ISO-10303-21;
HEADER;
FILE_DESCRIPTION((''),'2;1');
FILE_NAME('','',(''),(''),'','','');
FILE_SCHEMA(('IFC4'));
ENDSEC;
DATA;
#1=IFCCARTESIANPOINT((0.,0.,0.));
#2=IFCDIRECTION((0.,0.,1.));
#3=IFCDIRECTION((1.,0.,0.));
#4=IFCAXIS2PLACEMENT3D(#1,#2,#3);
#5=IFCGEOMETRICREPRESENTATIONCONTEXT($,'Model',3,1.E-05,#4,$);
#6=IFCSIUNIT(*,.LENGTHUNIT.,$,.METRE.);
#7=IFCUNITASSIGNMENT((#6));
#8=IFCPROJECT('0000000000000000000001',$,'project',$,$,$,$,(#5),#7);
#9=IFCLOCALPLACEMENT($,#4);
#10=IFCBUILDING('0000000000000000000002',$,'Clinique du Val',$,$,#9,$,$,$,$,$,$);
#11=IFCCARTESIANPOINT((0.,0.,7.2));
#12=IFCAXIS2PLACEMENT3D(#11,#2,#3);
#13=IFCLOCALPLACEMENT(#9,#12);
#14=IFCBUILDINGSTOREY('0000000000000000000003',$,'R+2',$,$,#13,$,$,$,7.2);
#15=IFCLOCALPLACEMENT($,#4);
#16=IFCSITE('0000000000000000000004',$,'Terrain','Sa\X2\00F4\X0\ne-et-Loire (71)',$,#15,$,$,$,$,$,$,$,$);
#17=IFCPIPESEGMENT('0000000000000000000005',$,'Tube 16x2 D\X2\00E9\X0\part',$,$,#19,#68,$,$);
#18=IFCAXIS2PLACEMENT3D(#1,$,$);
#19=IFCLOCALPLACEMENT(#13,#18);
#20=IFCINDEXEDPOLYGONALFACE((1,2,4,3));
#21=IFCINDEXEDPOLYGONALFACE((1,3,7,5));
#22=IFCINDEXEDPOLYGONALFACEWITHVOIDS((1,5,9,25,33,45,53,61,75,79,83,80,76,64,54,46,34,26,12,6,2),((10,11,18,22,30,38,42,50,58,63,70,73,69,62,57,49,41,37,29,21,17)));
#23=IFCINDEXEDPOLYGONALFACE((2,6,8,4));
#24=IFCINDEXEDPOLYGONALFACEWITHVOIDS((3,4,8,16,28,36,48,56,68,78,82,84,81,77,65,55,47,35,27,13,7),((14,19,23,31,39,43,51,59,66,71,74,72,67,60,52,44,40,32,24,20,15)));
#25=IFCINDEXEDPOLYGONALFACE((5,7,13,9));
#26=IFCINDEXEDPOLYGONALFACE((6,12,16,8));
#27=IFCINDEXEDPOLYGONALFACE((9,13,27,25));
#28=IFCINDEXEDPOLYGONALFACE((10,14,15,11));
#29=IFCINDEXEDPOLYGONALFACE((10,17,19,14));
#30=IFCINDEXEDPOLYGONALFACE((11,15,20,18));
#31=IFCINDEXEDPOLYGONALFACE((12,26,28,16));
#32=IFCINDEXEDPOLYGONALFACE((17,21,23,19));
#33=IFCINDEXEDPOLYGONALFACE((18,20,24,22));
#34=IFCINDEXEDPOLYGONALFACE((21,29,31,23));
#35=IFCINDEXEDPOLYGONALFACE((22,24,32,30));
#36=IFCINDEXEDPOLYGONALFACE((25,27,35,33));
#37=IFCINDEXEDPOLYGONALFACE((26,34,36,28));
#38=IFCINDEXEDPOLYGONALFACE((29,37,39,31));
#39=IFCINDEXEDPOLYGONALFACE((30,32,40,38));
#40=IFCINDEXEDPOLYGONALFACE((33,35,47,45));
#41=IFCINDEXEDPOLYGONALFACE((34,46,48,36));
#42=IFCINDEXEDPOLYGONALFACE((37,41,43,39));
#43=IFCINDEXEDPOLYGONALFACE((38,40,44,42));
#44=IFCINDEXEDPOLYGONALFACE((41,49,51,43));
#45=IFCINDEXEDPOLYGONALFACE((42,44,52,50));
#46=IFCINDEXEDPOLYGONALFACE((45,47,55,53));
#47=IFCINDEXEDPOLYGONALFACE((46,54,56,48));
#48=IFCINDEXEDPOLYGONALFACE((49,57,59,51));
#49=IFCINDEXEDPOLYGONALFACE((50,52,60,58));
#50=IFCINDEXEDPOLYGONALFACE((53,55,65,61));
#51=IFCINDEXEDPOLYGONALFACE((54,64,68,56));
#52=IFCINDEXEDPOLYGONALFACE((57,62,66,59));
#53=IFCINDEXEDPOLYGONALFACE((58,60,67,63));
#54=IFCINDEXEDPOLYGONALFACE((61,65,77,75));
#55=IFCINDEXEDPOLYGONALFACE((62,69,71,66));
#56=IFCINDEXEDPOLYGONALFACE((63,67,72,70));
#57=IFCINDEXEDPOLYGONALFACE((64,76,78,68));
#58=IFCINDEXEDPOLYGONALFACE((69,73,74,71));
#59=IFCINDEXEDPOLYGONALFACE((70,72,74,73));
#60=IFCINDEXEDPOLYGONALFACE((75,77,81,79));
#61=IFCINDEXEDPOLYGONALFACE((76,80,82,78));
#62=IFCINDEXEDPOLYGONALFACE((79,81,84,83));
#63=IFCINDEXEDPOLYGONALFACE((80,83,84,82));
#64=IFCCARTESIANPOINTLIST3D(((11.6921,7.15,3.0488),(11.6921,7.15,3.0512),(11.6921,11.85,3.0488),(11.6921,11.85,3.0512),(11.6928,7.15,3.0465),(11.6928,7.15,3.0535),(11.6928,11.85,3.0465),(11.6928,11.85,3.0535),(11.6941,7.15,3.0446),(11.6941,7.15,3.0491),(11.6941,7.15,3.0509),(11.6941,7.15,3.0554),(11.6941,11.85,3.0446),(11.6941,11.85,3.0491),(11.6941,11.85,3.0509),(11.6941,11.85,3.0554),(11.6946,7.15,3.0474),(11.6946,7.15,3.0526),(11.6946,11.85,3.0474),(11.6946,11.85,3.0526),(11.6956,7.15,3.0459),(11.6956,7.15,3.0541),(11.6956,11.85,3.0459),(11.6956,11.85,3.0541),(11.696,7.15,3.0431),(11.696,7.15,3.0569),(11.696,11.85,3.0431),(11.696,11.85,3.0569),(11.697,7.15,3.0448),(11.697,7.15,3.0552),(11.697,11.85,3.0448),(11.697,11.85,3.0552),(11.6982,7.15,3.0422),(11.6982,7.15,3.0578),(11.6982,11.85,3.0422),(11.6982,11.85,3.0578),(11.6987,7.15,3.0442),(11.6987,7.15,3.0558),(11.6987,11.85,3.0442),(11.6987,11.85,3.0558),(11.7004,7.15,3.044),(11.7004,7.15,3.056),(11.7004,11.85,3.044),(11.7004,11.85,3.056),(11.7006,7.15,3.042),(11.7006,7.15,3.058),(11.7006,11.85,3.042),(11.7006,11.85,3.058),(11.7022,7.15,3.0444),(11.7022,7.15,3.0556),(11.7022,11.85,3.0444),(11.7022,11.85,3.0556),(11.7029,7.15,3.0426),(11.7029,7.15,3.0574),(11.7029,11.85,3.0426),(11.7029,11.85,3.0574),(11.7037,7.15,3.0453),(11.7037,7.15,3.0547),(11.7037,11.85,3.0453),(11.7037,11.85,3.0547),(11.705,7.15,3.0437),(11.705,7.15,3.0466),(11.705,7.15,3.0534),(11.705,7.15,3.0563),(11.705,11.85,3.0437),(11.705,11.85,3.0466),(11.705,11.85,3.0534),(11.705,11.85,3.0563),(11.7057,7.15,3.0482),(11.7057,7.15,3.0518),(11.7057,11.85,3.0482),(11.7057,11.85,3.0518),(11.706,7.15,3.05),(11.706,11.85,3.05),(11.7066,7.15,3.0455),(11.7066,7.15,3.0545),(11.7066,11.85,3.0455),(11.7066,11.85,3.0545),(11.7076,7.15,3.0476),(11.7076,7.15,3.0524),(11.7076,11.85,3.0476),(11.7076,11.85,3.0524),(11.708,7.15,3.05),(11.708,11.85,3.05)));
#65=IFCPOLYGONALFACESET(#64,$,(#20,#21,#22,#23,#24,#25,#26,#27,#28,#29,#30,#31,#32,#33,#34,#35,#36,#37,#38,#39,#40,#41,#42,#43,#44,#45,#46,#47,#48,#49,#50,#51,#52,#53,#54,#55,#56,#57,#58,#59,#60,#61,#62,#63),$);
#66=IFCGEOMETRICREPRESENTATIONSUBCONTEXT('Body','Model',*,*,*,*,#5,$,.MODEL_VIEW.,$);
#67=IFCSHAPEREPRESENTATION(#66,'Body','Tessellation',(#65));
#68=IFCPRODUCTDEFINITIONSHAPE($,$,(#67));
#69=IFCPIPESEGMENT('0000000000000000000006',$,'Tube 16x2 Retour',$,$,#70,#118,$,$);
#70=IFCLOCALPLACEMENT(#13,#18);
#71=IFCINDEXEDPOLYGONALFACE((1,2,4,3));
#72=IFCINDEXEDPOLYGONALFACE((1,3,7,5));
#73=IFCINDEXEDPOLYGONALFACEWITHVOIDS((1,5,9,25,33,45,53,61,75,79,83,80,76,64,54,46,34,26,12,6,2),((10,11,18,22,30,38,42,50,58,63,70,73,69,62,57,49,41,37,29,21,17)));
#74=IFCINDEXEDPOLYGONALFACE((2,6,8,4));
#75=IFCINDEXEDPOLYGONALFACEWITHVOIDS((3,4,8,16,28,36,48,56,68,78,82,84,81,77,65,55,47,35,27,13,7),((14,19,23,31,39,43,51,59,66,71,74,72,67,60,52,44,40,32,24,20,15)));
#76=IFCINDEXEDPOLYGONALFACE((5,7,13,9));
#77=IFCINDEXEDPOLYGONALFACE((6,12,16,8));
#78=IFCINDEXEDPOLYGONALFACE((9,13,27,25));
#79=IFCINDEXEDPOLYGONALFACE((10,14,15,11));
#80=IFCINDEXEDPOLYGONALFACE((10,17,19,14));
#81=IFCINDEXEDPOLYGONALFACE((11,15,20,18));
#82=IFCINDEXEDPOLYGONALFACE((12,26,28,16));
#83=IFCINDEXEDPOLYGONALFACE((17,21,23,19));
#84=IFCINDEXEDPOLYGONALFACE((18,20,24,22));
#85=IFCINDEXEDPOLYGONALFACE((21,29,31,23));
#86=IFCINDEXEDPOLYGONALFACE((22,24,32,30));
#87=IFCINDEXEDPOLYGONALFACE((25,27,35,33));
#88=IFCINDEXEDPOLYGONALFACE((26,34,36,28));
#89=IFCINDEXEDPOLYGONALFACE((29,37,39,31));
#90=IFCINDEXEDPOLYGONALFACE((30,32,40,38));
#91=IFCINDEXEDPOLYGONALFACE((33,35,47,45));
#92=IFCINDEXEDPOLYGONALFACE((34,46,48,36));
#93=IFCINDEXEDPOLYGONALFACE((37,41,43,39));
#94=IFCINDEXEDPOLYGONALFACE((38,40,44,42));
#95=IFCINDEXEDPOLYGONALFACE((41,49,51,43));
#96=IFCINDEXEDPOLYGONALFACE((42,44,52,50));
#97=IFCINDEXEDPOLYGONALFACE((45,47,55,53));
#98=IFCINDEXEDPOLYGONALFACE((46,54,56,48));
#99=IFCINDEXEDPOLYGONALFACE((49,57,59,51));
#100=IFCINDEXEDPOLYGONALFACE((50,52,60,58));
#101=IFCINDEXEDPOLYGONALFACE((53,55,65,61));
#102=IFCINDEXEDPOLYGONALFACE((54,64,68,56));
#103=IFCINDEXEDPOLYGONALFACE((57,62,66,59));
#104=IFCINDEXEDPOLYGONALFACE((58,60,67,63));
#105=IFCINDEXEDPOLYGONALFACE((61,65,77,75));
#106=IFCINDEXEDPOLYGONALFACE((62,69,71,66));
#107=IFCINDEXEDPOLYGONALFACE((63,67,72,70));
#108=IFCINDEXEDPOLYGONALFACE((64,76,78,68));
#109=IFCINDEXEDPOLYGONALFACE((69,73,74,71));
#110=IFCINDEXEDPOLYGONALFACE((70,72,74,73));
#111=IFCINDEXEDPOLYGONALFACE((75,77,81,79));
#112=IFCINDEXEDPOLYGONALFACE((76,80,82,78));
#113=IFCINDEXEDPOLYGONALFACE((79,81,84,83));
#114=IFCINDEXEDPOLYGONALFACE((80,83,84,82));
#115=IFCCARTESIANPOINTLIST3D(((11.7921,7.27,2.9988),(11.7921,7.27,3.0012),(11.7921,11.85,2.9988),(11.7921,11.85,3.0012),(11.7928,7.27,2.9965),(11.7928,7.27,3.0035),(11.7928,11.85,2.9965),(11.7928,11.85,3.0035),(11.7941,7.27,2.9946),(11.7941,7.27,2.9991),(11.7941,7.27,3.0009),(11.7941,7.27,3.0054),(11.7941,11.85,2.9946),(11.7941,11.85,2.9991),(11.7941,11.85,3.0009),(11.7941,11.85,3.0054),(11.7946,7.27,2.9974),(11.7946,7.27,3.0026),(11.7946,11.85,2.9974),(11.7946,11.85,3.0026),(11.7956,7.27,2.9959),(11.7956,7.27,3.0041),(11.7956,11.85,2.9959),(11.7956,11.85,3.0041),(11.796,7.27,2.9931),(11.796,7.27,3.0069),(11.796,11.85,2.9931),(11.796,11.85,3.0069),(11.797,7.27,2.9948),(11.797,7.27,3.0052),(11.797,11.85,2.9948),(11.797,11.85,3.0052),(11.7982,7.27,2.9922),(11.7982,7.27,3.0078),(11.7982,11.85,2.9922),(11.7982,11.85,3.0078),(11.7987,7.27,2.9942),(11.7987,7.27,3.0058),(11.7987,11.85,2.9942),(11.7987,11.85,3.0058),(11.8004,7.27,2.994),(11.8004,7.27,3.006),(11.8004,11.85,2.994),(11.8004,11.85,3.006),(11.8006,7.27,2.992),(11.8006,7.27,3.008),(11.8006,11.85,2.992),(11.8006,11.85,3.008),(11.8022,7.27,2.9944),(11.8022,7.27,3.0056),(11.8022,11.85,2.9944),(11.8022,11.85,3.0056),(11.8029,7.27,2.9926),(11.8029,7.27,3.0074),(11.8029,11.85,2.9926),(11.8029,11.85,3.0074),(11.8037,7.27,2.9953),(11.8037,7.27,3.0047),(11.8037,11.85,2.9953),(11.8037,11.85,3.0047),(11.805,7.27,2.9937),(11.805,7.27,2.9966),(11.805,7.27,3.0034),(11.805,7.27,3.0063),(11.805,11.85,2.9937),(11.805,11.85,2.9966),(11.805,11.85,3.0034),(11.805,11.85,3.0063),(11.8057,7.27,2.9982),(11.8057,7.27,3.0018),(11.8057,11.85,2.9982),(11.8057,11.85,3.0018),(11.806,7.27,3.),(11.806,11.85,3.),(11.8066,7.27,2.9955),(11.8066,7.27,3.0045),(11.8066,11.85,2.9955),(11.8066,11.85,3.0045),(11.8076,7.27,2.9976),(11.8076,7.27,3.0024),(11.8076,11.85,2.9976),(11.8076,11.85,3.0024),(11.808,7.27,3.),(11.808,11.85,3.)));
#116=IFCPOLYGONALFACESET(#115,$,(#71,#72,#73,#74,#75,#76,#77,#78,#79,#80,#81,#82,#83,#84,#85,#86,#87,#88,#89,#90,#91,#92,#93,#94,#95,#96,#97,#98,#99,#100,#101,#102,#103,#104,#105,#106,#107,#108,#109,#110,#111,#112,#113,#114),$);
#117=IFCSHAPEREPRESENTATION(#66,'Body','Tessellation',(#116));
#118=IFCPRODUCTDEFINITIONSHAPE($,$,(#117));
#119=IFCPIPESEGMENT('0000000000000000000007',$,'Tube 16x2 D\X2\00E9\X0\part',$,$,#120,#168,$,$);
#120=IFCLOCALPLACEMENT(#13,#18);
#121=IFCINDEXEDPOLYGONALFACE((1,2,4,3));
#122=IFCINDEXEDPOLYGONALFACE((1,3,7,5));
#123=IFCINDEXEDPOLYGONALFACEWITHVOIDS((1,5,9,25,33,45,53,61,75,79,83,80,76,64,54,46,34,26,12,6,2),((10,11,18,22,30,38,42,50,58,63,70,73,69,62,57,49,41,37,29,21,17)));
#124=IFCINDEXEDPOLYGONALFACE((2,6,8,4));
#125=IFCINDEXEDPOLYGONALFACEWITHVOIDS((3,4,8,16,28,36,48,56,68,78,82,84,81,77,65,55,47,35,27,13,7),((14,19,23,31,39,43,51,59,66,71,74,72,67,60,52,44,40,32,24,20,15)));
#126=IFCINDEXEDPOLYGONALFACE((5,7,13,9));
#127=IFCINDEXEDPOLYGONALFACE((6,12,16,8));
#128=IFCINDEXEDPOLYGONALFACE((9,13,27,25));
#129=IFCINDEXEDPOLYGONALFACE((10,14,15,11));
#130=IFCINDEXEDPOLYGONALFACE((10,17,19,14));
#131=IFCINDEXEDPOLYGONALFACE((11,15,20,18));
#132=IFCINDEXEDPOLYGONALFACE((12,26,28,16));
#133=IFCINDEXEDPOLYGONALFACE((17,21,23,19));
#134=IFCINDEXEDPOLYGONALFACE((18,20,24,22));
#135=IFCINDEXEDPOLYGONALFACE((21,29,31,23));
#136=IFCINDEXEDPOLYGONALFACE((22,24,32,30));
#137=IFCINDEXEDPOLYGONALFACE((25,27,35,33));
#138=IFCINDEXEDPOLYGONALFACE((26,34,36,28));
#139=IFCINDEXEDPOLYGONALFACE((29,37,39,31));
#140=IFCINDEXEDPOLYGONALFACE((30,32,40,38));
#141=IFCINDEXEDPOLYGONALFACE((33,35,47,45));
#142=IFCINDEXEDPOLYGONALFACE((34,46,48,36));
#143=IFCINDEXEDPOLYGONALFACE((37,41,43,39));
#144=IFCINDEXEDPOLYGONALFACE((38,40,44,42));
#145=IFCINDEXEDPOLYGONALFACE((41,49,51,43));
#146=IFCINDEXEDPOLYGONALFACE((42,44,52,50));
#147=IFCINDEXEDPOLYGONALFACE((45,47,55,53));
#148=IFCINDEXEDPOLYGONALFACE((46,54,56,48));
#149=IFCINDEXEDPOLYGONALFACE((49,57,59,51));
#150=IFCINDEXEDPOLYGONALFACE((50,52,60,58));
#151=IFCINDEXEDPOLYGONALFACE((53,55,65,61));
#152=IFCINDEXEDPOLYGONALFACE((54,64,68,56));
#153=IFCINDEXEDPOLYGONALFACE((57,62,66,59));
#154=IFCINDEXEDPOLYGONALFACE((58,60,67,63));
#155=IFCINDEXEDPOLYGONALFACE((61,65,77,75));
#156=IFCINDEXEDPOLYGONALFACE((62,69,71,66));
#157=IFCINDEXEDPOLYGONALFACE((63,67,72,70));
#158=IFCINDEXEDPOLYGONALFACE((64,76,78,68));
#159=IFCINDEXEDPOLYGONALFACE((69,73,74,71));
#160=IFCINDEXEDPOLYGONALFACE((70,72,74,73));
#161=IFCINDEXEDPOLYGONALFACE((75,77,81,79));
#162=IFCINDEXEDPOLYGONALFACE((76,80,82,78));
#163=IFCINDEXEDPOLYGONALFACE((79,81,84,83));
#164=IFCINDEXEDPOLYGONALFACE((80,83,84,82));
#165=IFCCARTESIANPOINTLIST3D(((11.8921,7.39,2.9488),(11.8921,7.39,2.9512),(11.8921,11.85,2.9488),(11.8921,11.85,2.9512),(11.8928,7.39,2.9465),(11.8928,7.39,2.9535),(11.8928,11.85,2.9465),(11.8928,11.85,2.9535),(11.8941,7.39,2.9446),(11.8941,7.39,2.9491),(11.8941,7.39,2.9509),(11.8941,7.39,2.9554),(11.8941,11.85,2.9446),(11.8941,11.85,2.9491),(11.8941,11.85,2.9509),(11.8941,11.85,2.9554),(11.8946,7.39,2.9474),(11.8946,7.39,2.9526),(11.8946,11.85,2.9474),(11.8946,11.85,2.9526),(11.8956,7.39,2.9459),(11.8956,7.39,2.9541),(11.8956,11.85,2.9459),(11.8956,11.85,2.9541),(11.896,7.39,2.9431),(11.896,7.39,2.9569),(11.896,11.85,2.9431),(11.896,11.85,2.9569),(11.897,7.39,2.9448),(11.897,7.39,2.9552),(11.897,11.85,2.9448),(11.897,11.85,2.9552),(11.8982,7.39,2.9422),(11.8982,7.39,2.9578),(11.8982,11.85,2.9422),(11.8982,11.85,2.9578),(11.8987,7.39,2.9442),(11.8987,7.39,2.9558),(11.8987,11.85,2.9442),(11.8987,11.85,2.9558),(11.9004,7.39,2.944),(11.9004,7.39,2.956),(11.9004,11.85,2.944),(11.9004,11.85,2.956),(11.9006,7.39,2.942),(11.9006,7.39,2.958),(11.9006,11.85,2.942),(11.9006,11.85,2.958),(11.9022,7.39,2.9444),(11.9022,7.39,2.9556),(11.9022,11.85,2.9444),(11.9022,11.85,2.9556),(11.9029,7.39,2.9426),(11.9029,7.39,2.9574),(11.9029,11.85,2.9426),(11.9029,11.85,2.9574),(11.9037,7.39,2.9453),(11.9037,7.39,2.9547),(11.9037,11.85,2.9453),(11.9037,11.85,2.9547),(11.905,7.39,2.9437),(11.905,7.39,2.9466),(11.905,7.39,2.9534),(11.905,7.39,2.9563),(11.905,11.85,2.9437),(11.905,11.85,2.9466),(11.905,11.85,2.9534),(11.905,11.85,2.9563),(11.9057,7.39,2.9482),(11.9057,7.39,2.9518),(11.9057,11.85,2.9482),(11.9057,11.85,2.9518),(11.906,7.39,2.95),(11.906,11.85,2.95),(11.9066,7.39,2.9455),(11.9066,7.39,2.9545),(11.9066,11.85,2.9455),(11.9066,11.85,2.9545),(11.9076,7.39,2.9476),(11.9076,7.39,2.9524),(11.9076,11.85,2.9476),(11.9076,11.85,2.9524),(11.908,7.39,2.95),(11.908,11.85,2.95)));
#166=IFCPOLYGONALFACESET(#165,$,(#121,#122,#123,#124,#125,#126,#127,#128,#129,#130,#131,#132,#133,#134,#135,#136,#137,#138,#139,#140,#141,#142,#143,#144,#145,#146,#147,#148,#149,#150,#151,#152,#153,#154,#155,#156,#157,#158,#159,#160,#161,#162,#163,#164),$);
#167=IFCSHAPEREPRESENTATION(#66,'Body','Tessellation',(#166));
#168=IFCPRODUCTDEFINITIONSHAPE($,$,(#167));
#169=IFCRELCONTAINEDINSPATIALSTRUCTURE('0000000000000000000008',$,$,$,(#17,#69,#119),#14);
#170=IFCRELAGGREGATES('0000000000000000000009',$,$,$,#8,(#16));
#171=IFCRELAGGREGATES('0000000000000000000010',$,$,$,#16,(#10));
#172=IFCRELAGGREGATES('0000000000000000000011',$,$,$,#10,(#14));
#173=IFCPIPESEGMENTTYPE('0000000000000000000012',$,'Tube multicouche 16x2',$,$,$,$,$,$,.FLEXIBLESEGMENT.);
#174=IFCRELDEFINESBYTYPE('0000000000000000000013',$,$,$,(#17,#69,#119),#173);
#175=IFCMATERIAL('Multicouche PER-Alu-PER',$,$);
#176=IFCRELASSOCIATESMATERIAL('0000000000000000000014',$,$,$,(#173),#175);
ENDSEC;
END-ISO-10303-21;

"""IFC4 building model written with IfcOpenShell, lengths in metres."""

from ifc_helpers import new_model, si_unit, frame, origin_with_axes, place, context, subcontext, project, spatial, hollow_circle, extrude, material, type_object, element, save


model = new_model("IFC4")

# Units and contexts
model_context = context("Model", 3, precision=1e-05, world=origin_with_axes())
body_context = subcontext(model_context, "Body", "Model", "MODEL_VIEW")
ifc_project = project(units=[si_unit("LENGTHUNIT", "METRE")], contexts=[model_context])

# Site, building, storey
site_placement = place(None, origin_with_axes())
site = spatial("IfcSite", under=ifc_project, at=site_placement, Name="Terrain", Description="Saône-et-Loire (71)")
building_placement = place(None, origin_with_axes())
building = spatial("IfcBuilding", under=site, at=building_placement, Name="Clinique du Val")
storey_placement = place(building_placement, frame((0.0, 0.0, 7.2), z_axis=(0.0, 0.0, 1.0), x_axis=(1.0, 0.0, 0.0)))
storey = spatial("IfcBuildingStorey", under=building, at=storey_placement, Name="R+2", Elevation=7.2)

# Pipe segments
ifc_material_1 = material(Name="Multicouche PER-Alu-PER")
pipe_segment_type_1 = type_object("IfcPipeSegmentType", Name="Tube multicouche 16x2", PredefinedType="FLEXIBLESEGMENT", material=ifc_material_1)
pipe_segment_1_placement = place(storey_placement, frame((11.7, 7.15, 3.05), z_axis=(0.0, 1.0, 0.0), x_axis=(1.0, 0.0, 0.0)))
element("IfcPipeSegment", 1, at=pipe_segment_1_placement, inside=storey, type_object=pipe_segment_type_1, Name="Tube 16x2 Départ", context=body_context, shape_type="SweptSolid", body=[
    extrude(hollow_circle(Radius=0.008, WallThickness=0.002), origin_with_axes(), (0.0, 0.0, 1.0), 4.7),
])
pipe_segment_2_placement = place(storey_placement, frame((11.8, 7.27, 3.0), z_axis=(0.0, 1.0, 0.0), x_axis=(1.0, 0.0, 0.0)))
element("IfcPipeSegment", 2, at=pipe_segment_2_placement, inside=storey, type_object=pipe_segment_type_1, Name="Tube 16x2 Retour", context=body_context, shape_type="SweptSolid", body=[
    extrude(hollow_circle(Radius=0.008, WallThickness=0.002), origin_with_axes(), (0.0, 0.0, 1.0), 4.58),
])
pipe_segment_3_placement = place(storey_placement, frame((11.9, 7.39, 2.95), z_axis=(0.0, 1.0, 0.0), x_axis=(1.0, 0.0, 0.0)))
element("IfcPipeSegment", 3, at=pipe_segment_3_placement, inside=storey, type_object=pipe_segment_type_1, Name="Tube 16x2 Départ", context=body_context, shape_type="SweptSolid", body=[
    extrude(hollow_circle(Radius=0.008, WallThickness=0.002), origin_with_axes(), (0.0, 0.0, 1.0), 4.46),
])

save(model, "model.ifc")
